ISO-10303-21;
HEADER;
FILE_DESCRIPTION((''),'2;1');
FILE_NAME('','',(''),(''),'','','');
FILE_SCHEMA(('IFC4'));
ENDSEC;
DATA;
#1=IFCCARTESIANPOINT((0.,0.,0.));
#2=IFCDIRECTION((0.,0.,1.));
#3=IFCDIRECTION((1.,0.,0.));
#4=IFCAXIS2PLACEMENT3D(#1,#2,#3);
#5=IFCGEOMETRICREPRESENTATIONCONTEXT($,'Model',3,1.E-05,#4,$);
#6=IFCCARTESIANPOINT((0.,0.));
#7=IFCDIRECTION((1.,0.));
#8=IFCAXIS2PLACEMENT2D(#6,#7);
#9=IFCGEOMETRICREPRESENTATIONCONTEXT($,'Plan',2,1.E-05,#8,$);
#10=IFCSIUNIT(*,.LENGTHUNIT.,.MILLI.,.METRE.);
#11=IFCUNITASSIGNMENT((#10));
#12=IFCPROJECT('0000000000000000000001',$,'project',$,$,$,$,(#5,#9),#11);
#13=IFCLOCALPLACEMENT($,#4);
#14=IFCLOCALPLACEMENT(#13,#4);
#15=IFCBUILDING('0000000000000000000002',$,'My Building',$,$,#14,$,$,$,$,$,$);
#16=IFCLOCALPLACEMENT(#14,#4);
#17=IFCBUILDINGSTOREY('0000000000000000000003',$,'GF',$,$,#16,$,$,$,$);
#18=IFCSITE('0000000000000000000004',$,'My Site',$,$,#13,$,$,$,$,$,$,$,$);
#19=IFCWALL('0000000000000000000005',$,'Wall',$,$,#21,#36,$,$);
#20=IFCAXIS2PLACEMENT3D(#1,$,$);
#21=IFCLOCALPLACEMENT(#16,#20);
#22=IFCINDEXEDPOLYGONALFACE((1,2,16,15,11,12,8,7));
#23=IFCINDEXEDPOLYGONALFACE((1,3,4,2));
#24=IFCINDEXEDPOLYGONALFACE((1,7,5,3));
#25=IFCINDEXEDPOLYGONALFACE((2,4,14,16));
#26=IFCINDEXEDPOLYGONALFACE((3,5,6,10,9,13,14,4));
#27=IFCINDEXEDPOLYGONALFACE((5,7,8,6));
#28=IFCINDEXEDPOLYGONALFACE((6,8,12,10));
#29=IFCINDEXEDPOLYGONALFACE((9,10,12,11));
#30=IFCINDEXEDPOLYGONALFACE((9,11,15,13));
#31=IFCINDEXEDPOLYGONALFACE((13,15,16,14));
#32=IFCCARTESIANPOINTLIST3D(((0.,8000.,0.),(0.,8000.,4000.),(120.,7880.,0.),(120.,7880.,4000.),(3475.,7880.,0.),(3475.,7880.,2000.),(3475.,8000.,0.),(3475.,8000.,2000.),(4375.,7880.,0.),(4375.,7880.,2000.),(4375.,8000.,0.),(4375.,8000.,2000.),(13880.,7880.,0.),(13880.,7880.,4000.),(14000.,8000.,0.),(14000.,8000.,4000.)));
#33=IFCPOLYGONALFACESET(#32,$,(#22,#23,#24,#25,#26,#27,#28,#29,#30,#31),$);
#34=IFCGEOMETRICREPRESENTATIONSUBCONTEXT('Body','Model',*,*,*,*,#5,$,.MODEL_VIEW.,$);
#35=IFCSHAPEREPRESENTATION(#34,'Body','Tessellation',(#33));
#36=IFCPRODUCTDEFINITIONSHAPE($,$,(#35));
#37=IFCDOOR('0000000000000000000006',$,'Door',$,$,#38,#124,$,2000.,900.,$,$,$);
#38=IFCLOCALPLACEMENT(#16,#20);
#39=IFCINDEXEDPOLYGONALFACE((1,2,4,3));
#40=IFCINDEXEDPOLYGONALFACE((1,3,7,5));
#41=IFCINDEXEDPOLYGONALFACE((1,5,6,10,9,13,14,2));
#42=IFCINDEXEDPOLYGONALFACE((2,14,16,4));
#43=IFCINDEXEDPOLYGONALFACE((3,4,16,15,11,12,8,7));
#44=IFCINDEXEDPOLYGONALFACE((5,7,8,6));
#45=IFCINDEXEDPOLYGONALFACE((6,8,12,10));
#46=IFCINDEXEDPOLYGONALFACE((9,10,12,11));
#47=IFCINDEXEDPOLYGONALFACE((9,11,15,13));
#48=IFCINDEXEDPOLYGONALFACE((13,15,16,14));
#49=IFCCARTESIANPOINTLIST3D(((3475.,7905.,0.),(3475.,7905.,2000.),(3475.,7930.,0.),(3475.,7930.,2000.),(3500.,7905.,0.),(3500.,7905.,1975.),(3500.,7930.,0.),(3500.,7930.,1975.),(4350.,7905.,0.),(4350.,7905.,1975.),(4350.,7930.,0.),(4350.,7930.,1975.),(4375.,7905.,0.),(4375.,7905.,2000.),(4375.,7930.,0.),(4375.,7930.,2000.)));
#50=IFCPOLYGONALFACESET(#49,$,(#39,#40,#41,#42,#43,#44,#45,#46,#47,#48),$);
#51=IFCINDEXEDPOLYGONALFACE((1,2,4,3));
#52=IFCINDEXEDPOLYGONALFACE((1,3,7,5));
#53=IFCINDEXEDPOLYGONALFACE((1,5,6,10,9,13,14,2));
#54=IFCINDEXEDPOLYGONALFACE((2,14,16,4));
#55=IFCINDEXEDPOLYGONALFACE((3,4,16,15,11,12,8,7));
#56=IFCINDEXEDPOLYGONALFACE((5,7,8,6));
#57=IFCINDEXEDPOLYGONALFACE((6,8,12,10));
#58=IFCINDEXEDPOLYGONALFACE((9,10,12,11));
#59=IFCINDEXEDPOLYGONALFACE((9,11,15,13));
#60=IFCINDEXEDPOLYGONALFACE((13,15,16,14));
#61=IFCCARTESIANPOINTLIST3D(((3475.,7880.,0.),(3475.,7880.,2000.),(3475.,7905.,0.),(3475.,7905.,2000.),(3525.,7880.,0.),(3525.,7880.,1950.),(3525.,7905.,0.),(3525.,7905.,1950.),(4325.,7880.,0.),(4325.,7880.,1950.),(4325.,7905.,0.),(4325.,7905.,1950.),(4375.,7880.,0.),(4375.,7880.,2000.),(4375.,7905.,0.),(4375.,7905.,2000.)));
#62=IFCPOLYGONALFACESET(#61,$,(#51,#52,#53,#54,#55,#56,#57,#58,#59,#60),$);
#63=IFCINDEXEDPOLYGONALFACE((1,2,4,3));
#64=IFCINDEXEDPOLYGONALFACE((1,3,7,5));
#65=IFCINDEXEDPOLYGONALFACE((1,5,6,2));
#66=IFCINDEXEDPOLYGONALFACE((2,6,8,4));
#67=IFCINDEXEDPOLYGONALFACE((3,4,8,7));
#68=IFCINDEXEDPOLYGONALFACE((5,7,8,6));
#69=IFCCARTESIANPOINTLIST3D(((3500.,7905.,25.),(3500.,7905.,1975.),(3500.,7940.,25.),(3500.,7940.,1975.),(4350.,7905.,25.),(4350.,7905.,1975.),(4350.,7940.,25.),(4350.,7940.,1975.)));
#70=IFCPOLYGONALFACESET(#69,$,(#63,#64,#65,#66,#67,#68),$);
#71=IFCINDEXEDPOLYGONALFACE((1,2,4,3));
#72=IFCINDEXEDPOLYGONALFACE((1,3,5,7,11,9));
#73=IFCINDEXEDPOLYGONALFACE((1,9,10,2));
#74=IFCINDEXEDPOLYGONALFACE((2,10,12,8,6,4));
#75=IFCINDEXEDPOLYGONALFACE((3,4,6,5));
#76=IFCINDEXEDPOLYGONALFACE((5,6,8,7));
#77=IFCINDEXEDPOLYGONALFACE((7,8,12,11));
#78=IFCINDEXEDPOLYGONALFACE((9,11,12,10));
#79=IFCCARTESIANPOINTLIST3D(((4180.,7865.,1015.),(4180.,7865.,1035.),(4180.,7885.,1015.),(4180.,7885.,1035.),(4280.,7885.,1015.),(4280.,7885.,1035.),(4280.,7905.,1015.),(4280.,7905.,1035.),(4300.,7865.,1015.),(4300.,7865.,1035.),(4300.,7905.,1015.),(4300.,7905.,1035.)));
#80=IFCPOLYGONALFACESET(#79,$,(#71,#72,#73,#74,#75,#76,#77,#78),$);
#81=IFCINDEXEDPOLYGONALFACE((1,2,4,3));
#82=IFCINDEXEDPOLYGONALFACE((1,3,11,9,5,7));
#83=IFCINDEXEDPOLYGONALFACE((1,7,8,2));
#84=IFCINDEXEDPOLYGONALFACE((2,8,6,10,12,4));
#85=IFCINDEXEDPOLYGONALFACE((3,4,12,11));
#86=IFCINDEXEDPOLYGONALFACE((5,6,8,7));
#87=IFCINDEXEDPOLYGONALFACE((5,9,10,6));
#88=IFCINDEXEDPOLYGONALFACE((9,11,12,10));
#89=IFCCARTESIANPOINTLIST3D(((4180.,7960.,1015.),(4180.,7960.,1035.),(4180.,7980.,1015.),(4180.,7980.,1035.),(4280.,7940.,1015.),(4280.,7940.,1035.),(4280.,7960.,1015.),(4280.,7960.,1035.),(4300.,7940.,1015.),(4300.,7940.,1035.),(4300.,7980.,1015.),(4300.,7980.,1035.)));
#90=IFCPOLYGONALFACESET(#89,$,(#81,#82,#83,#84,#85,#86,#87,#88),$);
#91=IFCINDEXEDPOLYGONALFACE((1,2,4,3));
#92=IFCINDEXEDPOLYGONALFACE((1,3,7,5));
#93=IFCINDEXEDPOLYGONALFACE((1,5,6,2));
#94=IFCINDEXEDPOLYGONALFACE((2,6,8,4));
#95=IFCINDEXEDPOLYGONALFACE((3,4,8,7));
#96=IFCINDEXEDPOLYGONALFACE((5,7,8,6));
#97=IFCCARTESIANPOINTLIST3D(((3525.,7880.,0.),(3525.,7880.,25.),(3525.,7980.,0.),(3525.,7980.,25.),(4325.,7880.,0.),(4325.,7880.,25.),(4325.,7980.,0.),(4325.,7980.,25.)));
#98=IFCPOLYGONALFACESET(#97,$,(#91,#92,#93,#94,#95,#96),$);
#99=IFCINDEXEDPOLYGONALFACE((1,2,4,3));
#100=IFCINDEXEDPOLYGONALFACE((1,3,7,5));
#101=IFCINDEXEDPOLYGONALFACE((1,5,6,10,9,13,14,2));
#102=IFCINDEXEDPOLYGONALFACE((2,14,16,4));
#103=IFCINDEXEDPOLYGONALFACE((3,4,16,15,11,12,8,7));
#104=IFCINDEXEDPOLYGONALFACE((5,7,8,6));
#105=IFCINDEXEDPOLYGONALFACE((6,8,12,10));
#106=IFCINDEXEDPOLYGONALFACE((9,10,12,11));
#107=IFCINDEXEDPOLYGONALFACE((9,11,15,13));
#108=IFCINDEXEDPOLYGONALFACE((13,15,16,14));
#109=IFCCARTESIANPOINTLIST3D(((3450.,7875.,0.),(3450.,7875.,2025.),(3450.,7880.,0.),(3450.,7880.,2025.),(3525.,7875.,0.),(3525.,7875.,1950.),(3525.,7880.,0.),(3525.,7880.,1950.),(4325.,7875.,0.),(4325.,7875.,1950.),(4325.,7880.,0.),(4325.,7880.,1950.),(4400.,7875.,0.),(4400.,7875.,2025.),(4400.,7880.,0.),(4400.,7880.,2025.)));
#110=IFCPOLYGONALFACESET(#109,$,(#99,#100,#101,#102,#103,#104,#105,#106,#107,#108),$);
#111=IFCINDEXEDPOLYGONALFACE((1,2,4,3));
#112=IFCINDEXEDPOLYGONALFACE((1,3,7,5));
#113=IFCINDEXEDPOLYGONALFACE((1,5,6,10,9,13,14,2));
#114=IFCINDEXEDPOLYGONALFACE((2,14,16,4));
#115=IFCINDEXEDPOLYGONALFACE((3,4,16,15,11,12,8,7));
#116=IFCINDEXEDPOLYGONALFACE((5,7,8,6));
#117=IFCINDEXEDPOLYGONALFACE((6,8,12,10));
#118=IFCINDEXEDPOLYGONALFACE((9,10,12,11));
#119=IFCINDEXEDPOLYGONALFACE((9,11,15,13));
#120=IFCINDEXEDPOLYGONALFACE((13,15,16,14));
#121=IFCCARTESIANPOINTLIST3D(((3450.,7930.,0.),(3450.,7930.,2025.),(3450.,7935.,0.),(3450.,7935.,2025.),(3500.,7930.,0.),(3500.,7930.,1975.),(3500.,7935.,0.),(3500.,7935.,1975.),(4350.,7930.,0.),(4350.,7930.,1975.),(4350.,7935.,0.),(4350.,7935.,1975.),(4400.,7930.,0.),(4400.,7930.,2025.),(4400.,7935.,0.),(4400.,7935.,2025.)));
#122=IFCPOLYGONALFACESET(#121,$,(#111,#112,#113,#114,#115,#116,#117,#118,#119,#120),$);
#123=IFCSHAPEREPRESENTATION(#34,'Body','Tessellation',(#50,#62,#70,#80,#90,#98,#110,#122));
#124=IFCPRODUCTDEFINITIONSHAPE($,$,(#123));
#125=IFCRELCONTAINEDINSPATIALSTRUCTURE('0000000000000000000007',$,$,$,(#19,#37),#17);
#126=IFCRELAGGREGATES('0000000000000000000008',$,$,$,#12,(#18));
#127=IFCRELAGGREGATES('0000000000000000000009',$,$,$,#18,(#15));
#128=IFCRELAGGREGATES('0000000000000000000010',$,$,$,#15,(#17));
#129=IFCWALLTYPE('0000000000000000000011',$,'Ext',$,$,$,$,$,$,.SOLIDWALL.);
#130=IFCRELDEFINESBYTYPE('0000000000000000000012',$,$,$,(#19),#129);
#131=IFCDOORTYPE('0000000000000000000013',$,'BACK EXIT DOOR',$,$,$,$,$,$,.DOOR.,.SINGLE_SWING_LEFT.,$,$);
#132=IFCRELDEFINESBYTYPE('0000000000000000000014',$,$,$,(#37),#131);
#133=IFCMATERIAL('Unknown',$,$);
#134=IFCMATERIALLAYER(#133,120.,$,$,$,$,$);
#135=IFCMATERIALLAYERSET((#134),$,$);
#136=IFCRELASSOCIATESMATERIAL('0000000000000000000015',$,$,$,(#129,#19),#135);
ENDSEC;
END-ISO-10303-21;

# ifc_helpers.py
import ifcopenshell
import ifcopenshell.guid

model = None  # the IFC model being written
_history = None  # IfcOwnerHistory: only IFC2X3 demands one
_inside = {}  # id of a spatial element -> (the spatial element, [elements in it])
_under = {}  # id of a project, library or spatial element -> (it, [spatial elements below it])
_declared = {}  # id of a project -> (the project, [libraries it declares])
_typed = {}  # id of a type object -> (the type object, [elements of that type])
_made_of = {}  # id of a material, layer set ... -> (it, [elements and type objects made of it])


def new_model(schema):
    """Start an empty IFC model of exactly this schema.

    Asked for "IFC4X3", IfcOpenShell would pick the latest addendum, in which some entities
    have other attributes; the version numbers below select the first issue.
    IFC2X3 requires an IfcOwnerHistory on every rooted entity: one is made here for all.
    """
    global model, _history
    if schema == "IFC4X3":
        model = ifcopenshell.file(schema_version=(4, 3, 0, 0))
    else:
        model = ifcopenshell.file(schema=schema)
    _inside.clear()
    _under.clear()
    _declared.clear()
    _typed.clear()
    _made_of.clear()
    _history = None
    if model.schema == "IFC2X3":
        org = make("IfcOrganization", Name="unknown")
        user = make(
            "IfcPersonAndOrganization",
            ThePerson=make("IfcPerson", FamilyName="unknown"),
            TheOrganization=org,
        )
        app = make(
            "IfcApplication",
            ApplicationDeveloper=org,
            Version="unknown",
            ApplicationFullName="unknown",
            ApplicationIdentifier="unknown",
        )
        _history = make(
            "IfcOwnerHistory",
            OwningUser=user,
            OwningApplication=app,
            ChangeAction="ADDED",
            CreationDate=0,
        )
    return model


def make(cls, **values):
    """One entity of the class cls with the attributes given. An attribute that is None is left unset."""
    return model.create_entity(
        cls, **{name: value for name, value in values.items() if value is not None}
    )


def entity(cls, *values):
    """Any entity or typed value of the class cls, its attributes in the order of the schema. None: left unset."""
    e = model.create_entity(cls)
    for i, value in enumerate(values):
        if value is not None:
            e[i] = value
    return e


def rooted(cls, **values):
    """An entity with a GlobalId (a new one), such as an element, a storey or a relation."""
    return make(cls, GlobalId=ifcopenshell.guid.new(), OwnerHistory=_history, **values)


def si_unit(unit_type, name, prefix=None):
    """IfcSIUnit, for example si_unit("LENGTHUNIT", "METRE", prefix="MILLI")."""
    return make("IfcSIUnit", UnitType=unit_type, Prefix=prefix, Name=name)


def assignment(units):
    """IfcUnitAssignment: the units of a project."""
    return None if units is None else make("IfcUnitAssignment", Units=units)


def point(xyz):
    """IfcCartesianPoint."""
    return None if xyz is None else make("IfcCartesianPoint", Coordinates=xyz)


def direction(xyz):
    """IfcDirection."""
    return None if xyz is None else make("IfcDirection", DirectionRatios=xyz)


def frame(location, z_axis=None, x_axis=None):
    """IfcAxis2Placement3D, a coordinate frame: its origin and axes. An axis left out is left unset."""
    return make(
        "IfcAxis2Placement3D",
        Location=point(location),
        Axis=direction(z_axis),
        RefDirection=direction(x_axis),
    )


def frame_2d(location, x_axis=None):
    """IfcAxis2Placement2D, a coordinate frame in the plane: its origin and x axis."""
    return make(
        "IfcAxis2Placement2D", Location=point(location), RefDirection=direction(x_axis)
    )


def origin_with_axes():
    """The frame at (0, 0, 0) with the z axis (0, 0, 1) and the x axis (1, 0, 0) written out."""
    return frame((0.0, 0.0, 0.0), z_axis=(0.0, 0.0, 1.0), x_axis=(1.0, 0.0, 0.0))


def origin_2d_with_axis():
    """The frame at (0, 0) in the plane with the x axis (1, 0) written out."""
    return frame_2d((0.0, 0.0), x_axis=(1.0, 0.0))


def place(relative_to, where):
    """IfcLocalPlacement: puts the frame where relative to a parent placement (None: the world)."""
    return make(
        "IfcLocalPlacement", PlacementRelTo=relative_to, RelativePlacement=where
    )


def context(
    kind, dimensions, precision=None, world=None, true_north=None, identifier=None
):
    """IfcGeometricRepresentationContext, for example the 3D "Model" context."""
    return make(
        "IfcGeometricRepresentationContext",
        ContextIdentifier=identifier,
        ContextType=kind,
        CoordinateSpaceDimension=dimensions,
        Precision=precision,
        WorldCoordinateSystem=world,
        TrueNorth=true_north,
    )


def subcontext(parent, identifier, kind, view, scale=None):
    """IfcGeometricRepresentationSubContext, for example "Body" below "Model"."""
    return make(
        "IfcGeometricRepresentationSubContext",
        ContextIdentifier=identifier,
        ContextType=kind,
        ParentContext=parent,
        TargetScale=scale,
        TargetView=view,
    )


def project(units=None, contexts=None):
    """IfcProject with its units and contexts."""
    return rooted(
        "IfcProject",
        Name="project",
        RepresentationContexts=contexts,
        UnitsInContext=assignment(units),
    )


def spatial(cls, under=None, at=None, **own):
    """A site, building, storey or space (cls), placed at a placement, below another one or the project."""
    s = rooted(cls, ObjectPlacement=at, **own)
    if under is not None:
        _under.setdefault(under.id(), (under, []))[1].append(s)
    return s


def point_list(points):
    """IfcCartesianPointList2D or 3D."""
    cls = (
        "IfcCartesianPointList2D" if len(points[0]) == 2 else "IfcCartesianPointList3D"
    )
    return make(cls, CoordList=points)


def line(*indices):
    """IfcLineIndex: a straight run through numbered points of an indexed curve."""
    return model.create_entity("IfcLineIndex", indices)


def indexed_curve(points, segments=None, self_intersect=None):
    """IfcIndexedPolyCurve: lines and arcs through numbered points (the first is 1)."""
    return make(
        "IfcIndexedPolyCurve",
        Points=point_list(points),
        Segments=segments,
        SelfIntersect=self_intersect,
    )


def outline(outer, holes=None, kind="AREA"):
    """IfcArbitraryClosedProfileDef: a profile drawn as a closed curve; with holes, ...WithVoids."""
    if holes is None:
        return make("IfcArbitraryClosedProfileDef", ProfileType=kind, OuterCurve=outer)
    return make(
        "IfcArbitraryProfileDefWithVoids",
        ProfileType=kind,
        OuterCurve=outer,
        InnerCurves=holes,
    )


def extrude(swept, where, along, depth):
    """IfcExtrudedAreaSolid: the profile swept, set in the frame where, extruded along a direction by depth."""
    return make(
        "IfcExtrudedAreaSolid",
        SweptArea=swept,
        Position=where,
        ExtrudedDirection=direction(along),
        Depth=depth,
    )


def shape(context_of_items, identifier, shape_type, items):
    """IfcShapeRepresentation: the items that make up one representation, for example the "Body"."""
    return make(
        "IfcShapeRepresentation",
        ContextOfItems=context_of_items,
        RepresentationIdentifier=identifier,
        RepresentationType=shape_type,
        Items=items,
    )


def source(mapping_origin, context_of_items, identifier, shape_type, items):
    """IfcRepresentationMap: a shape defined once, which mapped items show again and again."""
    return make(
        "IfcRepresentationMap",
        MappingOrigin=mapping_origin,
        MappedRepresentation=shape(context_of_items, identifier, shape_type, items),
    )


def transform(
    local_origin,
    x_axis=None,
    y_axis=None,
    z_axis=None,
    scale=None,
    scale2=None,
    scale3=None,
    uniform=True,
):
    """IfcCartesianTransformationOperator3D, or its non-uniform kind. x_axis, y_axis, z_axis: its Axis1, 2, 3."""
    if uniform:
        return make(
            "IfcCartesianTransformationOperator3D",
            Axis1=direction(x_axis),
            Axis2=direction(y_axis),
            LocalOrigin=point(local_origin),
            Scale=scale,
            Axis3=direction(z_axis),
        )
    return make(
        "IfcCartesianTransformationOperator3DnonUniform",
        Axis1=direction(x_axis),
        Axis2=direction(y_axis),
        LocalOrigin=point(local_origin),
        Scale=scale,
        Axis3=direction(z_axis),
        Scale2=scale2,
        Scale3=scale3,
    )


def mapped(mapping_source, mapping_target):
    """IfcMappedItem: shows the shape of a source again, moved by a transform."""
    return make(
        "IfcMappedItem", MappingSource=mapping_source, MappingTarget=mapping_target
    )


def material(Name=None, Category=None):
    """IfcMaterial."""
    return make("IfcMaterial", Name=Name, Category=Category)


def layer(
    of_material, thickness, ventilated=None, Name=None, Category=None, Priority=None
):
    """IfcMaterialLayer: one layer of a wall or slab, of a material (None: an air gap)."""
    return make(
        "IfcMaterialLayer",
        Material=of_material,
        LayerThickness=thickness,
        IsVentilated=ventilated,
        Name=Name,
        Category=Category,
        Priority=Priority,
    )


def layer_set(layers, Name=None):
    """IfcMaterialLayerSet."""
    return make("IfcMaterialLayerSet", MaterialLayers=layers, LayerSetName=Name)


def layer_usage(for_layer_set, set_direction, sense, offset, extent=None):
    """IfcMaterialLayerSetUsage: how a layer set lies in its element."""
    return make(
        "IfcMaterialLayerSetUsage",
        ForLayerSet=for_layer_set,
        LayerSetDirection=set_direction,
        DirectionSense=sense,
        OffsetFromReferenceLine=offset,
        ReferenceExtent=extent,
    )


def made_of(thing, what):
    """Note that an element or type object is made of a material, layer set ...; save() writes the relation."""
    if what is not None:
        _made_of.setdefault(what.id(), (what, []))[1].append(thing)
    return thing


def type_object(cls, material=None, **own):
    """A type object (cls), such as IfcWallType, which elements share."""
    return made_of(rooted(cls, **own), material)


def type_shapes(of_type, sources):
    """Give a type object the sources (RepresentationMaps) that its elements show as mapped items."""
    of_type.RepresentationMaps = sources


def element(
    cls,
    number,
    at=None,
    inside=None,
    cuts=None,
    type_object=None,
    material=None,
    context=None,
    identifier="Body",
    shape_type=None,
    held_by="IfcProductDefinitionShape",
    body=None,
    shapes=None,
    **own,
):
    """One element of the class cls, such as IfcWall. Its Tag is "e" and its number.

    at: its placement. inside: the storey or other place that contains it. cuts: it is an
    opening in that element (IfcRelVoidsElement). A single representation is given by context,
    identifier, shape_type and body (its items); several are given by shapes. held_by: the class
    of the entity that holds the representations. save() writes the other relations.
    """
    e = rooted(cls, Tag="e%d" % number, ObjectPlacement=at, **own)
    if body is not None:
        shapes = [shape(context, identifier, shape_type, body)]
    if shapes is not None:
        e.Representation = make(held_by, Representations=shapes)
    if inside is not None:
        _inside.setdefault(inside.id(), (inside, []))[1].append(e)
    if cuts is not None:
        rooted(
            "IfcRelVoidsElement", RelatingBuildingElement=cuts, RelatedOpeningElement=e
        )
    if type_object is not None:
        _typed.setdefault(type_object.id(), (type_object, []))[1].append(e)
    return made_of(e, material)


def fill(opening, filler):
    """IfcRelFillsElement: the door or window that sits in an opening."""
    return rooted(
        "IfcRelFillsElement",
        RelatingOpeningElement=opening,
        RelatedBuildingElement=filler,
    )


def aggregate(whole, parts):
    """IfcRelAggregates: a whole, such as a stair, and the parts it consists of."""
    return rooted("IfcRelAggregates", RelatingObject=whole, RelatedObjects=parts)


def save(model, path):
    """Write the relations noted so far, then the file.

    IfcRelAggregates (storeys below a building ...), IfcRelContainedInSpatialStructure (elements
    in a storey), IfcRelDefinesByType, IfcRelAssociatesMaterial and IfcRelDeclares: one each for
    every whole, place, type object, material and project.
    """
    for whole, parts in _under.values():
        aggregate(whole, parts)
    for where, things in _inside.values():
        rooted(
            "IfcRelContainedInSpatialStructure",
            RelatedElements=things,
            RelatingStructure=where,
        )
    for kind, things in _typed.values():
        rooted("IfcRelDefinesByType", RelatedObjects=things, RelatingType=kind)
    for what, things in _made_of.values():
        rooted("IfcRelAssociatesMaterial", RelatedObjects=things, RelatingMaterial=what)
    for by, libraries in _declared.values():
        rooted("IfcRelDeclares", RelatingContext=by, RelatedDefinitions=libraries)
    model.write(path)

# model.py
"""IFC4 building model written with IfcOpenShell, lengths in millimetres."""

from ifc_helpers import new_model, entity, si_unit, frame, origin_with_axes, origin_2d_with_axis, place, context, subcontext, project, spatial, line, indexed_curve, outline, extrude, shape, source, transform, mapped, material, layer, layer_set, layer_usage, type_object, type_shapes, element, fill, save


model = new_model("IFC4")

# Units and contexts
model_context = context("Model", 3, precision=1e-05, world=origin_with_axes())
plan_context = context("Plan", 2, precision=1e-05, world=origin_2d_with_axis())
body_context_1 = subcontext(model_context, "Body", "Model", "MODEL_VIEW")
body_context_2 = subcontext(plan_context, "Body", "Plan", "PLAN_VIEW")
ifc_project = project(units=[si_unit("LENGTHUNIT", "METRE", prefix="MILLI")], contexts=[model_context, plan_context])

# Site, building, storey
site_placement = place(None, origin_with_axes())
site = spatial("IfcSite", under=ifc_project, at=site_placement, Name="My Site")
building_placement = place(site_placement, origin_with_axes())
building = spatial("IfcBuilding", under=site, at=building_placement, Name="My Building")
storey_placement = place(building_placement, origin_with_axes())
storey = spatial("IfcBuildingStorey", under=building, at=storey_placement, Name="GF")

# Shared definitions
ifc_material = material(Name="Unknown")

# Shared definitions
ifc_layer_1 = layer(ifc_material, 120.0)
ifc_layer_set_1 = layer_set([ifc_layer_1])
wall_type_1 = type_object("IfcWallType", Name="Ext", PredefinedType="SOLIDWALL", material=ifc_layer_set_1)

# Wall, opening, door
ifc_layer_usage_1 = layer_usage(ifc_layer_set_1, "AXIS2", "POSITIVE", 0.0)
wall_1_placement = place(storey_placement, frame((14000.0, 8000.0, 0.0), z_axis=(0.0, 0.0, 1.0), x_axis=(-1.0, 0.0, 0.0)))
wall_1 = element("IfcWall", 1, at=wall_1_placement, inside=storey, type_object=wall_type_1, material=ifc_layer_usage_1, Name="Wall", context=body_context_1, shape_type="SweptSolid", body=[
    extrude(outline(indexed_curve([(0.0, 0.0), (120.0, 120.0), (13880.0, 120.0), (14000.0, 0.0)], segments=[line(1, 2, 3, 4, 1)])), origin_with_axes(), (0.0, 0.0, 1.0), 4000.0),
])
shared_shape_1 = source(origin_with_axes(), body_context_1, "Body", "SweptSolid", [
    extrude(outline(indexed_curve([(0.0, 0.0), (900.0, 0.0), (900.0, 2000.0), (0.0, 2000.0)], segments=[line(1, 2, 3, 4, 1)])), frame((0.0, -600.0, 0.0), z_axis=(0.0, -1.0, 0.0), x_axis=(1.0, 0.0, 0.0)), (0.0, 0.0, -1.0), 1200.0),
])
opening_1_placement = place(wall_1_placement, frame((10525.0, 120.0, 0.0), z_axis=(0.0, 0.0, 1.0), x_axis=(-1.0, 0.0, 0.0)))
opening_1 = element("IfcOpeningElement", 2, at=opening_1_placement, cuts=wall_1, PredefinedType="OPENING", context=body_context_1, shape_type="MappedRepresentation", body=[
    mapped(shared_shape_1, transform((0.0, 0.0, 0.0), x_axis=(1.0, 0.0, 0.0), y_axis=(0.0, 1.0, 0.0), z_axis=(0.0, 0.0, 1.0), scale=1.0)),
])
door_type_1 = type_object("IfcDoorType", Name="BACK EXIT DOOR", OperationType="SINGLE_SWING_LEFT", PredefinedType="DOOR")
shared_shape_2 = source(origin_with_axes(), body_context_1, "Body", "SweptSolid", [
    extrude(outline(indexed_curve([(0.0, 0.0), (0.0, 2000.0), (900.0, 2000.0), (900.0, 0.0), (875.0, 0.0), (875.0, 1975.0), (25.0, 1975.0), (25.0, 0.0)], segments=[line(1, 2, 3, 4, 5, 6, 7, 8, 1)])), frame((0.0, 25.0, 0.0), z_axis=(0.0, -1.0, 0.0), x_axis=(1.0, 0.0, 0.0)), (0.0, 0.0, -1.0), 25.0),
    extrude(outline(indexed_curve([(0.0, 0.0), (0.0, 2000.0), (900.0, 2000.0), (900.0, 0.0), (850.0, 0.0), (850.0, 1950.0), (50.0, 1950.0), (50.0, 0.0)], segments=[line(1, 2, 3, 4, 5, 6, 7, 8, 1)])), frame((0.0, 0.0, 0.0), z_axis=(0.0, -1.0, 0.0), x_axis=(1.0, 0.0, 0.0)), (0.0, 0.0, -1.0), 25.0),
    extrude(outline(indexed_curve([(0.0, 0.0), (850.0, 0.0), (850.0, 35.0), (0.0, 35.0)], segments=[line(1, 2, 3, 4, 1)])), frame((25.0, 25.0, 25.0), z_axis=(0.0, 0.0, 1.0), x_axis=(1.0, 0.0, 0.0)), (0.0, 0.0, 1.0), 1950.0),
    extrude(outline(indexed_curve([(0.0, 0.0), (0.0, -40.0), (-120.0, -40.0), (-120.0, -20.0), (-20.0, -20.0), (-20.0, 0.0)], segments=[line(1, 2, 3, 4, 5, 6, 1)])), frame((825.0, 25.0, 1015.0), z_axis=(0.0, 0.0, 1.0), x_axis=(1.0, 0.0, 0.0)), (0.0, 0.0, 1.0), 20.0),
    extrude(outline(indexed_curve([(0.0, 0.0), (0.0, 40.0), (-120.0, 40.0), (-120.0, 20.0), (-20.0, 20.0), (-20.0, 0.0)], segments=[line(1, 2, 3, 4, 5, 6, 1)])), frame((825.0, 60.0, 1015.0), z_axis=(0.0, 0.0, 1.0), x_axis=(1.0, 0.0, 0.0)), (0.0, 0.0, 1.0), 20.0),
    extrude(outline(indexed_curve([(0.0, 0.0), (800.0, 0.0), (800.0, 100.0), (0.0, 100.0)], segments=[line(1, 2, 3, 4, 1)])), frame((50.0, 0.0, 0.0), z_axis=(0.0, 0.0, 1.0), x_axis=(1.0, 0.0, 0.0)), (0.0, 0.0, 1.0), 25.0),
    extrude(outline(indexed_curve([(0.0, 0.0), (0.0, 2025.0), (950.0, 2025.0), (950.0, 0.0), (875.0, 0.0), (875.0, 1950.0), (75.0, 1950.0), (75.0, 0.0)], segments=[line(1, 2, 3, 4, 5, 6, 7, 8, 1)])), frame((-25.0, -5.0, 0.0), z_axis=(0.0, -1.0, 0.0), x_axis=(1.0, 0.0, 0.0)), (0.0, 0.0, -1.0), 5.0),
    extrude(outline(indexed_curve([(0.0, 0.0), (0.0, 2025.0), (950.0, 2025.0), (950.0, 0.0), (900.0, 0.0), (900.0, 1975.0), (50.0, 1975.0), (50.0, 0.0)], segments=[line(1, 2, 3, 4, 5, 6, 7, 8, 1)])), frame((-25.0, 50.0, 0.0), z_axis=(0.0, -1.0, 0.0), x_axis=(1.0, 0.0, 0.0)), (0.0, 0.0, -1.0), 5.0),
])
shared_shape_3 = source(origin_with_axes(), body_context_2, "Body", "Curve2D", [
    entity("IfcIndexedPolyCurve", entity("IfcCartesianPointList2D", [[0.0, 0.0], [0.0, 50.0], [25.0, 50.0], [25.0, 25.0], [50.0, 25.0], [50.0, 0.0]]), [entity("IfcLineIndex", [1, 2, 3, 4, 5, 6, 1])]),
    entity("IfcIndexedPolyCurve", entity("IfcCartesianPointList2D", [[900.0, 0.0], [900.0, 50.0], [875.0, 50.0], [875.0, 25.0], [850.0, 25.0], [850.0, 0.0]]), [entity("IfcLineIndex", [1, 2, 3, 4, 5, 6, 1])]),
    entity("IfcTrimmedCurve", entity("IfcEllipse", entity("IfcAxis2Placement2D", entity("IfcCartesianPoint", [60.0, 50.0]), entity("IfcDirection", [1.0, 0.0])), 815.0, 850.0), [entity("IfcCartesianPoint", [875.0, 50.0])], [entity("IfcCartesianPoint", [60.0, 900.0])], True, "CARTESIAN"),
    entity("IfcIndexedPolyCurve", entity("IfcCartesianPointList2D", [[25.0, 50.0], [60.0, 50.0], [60.0, 900.0], [25.0, 900.0]]), [entity("IfcLineIndex", [1, 2, 3, 4, 1])]),
])
type_shapes(door_type_1, [shared_shape_2, shared_shape_3])
door_1_placement = place(opening_1_placement, frame((0.0, 0.0, 0.0), z_axis=(0.0, 0.0, 1.0), x_axis=(1.0, 0.0, 0.0)))
door_1 = element("IfcDoor", 3, at=door_1_placement, inside=storey, type_object=door_type_1, Name="Door", OverallHeight=2000.0, OverallWidth=900.0, shapes=[
    shape(body_context_1, "Body", "MappedRepresentation", [mapped(shared_shape_2, transform((0.0, 0.0, 0.0), x_axis=(1.0, 0.0, 0.0), y_axis=(0.0, 1.0, 0.0), z_axis=(0.0, 0.0, 1.0), scale=1.0))]),
    shape(body_context_2, "Body", "MappedRepresentation", [mapped(shared_shape_3, transform((0.0, 0.0, 0.0), x_axis=(1.0, 0.0, 0.0), y_axis=(0.0, 1.0, 0.0), z_axis=(0.0, 0.0, 1.0), scale=1.0))]),
])
fill(opening_1, door_1)

save(model, "model.ifc")
